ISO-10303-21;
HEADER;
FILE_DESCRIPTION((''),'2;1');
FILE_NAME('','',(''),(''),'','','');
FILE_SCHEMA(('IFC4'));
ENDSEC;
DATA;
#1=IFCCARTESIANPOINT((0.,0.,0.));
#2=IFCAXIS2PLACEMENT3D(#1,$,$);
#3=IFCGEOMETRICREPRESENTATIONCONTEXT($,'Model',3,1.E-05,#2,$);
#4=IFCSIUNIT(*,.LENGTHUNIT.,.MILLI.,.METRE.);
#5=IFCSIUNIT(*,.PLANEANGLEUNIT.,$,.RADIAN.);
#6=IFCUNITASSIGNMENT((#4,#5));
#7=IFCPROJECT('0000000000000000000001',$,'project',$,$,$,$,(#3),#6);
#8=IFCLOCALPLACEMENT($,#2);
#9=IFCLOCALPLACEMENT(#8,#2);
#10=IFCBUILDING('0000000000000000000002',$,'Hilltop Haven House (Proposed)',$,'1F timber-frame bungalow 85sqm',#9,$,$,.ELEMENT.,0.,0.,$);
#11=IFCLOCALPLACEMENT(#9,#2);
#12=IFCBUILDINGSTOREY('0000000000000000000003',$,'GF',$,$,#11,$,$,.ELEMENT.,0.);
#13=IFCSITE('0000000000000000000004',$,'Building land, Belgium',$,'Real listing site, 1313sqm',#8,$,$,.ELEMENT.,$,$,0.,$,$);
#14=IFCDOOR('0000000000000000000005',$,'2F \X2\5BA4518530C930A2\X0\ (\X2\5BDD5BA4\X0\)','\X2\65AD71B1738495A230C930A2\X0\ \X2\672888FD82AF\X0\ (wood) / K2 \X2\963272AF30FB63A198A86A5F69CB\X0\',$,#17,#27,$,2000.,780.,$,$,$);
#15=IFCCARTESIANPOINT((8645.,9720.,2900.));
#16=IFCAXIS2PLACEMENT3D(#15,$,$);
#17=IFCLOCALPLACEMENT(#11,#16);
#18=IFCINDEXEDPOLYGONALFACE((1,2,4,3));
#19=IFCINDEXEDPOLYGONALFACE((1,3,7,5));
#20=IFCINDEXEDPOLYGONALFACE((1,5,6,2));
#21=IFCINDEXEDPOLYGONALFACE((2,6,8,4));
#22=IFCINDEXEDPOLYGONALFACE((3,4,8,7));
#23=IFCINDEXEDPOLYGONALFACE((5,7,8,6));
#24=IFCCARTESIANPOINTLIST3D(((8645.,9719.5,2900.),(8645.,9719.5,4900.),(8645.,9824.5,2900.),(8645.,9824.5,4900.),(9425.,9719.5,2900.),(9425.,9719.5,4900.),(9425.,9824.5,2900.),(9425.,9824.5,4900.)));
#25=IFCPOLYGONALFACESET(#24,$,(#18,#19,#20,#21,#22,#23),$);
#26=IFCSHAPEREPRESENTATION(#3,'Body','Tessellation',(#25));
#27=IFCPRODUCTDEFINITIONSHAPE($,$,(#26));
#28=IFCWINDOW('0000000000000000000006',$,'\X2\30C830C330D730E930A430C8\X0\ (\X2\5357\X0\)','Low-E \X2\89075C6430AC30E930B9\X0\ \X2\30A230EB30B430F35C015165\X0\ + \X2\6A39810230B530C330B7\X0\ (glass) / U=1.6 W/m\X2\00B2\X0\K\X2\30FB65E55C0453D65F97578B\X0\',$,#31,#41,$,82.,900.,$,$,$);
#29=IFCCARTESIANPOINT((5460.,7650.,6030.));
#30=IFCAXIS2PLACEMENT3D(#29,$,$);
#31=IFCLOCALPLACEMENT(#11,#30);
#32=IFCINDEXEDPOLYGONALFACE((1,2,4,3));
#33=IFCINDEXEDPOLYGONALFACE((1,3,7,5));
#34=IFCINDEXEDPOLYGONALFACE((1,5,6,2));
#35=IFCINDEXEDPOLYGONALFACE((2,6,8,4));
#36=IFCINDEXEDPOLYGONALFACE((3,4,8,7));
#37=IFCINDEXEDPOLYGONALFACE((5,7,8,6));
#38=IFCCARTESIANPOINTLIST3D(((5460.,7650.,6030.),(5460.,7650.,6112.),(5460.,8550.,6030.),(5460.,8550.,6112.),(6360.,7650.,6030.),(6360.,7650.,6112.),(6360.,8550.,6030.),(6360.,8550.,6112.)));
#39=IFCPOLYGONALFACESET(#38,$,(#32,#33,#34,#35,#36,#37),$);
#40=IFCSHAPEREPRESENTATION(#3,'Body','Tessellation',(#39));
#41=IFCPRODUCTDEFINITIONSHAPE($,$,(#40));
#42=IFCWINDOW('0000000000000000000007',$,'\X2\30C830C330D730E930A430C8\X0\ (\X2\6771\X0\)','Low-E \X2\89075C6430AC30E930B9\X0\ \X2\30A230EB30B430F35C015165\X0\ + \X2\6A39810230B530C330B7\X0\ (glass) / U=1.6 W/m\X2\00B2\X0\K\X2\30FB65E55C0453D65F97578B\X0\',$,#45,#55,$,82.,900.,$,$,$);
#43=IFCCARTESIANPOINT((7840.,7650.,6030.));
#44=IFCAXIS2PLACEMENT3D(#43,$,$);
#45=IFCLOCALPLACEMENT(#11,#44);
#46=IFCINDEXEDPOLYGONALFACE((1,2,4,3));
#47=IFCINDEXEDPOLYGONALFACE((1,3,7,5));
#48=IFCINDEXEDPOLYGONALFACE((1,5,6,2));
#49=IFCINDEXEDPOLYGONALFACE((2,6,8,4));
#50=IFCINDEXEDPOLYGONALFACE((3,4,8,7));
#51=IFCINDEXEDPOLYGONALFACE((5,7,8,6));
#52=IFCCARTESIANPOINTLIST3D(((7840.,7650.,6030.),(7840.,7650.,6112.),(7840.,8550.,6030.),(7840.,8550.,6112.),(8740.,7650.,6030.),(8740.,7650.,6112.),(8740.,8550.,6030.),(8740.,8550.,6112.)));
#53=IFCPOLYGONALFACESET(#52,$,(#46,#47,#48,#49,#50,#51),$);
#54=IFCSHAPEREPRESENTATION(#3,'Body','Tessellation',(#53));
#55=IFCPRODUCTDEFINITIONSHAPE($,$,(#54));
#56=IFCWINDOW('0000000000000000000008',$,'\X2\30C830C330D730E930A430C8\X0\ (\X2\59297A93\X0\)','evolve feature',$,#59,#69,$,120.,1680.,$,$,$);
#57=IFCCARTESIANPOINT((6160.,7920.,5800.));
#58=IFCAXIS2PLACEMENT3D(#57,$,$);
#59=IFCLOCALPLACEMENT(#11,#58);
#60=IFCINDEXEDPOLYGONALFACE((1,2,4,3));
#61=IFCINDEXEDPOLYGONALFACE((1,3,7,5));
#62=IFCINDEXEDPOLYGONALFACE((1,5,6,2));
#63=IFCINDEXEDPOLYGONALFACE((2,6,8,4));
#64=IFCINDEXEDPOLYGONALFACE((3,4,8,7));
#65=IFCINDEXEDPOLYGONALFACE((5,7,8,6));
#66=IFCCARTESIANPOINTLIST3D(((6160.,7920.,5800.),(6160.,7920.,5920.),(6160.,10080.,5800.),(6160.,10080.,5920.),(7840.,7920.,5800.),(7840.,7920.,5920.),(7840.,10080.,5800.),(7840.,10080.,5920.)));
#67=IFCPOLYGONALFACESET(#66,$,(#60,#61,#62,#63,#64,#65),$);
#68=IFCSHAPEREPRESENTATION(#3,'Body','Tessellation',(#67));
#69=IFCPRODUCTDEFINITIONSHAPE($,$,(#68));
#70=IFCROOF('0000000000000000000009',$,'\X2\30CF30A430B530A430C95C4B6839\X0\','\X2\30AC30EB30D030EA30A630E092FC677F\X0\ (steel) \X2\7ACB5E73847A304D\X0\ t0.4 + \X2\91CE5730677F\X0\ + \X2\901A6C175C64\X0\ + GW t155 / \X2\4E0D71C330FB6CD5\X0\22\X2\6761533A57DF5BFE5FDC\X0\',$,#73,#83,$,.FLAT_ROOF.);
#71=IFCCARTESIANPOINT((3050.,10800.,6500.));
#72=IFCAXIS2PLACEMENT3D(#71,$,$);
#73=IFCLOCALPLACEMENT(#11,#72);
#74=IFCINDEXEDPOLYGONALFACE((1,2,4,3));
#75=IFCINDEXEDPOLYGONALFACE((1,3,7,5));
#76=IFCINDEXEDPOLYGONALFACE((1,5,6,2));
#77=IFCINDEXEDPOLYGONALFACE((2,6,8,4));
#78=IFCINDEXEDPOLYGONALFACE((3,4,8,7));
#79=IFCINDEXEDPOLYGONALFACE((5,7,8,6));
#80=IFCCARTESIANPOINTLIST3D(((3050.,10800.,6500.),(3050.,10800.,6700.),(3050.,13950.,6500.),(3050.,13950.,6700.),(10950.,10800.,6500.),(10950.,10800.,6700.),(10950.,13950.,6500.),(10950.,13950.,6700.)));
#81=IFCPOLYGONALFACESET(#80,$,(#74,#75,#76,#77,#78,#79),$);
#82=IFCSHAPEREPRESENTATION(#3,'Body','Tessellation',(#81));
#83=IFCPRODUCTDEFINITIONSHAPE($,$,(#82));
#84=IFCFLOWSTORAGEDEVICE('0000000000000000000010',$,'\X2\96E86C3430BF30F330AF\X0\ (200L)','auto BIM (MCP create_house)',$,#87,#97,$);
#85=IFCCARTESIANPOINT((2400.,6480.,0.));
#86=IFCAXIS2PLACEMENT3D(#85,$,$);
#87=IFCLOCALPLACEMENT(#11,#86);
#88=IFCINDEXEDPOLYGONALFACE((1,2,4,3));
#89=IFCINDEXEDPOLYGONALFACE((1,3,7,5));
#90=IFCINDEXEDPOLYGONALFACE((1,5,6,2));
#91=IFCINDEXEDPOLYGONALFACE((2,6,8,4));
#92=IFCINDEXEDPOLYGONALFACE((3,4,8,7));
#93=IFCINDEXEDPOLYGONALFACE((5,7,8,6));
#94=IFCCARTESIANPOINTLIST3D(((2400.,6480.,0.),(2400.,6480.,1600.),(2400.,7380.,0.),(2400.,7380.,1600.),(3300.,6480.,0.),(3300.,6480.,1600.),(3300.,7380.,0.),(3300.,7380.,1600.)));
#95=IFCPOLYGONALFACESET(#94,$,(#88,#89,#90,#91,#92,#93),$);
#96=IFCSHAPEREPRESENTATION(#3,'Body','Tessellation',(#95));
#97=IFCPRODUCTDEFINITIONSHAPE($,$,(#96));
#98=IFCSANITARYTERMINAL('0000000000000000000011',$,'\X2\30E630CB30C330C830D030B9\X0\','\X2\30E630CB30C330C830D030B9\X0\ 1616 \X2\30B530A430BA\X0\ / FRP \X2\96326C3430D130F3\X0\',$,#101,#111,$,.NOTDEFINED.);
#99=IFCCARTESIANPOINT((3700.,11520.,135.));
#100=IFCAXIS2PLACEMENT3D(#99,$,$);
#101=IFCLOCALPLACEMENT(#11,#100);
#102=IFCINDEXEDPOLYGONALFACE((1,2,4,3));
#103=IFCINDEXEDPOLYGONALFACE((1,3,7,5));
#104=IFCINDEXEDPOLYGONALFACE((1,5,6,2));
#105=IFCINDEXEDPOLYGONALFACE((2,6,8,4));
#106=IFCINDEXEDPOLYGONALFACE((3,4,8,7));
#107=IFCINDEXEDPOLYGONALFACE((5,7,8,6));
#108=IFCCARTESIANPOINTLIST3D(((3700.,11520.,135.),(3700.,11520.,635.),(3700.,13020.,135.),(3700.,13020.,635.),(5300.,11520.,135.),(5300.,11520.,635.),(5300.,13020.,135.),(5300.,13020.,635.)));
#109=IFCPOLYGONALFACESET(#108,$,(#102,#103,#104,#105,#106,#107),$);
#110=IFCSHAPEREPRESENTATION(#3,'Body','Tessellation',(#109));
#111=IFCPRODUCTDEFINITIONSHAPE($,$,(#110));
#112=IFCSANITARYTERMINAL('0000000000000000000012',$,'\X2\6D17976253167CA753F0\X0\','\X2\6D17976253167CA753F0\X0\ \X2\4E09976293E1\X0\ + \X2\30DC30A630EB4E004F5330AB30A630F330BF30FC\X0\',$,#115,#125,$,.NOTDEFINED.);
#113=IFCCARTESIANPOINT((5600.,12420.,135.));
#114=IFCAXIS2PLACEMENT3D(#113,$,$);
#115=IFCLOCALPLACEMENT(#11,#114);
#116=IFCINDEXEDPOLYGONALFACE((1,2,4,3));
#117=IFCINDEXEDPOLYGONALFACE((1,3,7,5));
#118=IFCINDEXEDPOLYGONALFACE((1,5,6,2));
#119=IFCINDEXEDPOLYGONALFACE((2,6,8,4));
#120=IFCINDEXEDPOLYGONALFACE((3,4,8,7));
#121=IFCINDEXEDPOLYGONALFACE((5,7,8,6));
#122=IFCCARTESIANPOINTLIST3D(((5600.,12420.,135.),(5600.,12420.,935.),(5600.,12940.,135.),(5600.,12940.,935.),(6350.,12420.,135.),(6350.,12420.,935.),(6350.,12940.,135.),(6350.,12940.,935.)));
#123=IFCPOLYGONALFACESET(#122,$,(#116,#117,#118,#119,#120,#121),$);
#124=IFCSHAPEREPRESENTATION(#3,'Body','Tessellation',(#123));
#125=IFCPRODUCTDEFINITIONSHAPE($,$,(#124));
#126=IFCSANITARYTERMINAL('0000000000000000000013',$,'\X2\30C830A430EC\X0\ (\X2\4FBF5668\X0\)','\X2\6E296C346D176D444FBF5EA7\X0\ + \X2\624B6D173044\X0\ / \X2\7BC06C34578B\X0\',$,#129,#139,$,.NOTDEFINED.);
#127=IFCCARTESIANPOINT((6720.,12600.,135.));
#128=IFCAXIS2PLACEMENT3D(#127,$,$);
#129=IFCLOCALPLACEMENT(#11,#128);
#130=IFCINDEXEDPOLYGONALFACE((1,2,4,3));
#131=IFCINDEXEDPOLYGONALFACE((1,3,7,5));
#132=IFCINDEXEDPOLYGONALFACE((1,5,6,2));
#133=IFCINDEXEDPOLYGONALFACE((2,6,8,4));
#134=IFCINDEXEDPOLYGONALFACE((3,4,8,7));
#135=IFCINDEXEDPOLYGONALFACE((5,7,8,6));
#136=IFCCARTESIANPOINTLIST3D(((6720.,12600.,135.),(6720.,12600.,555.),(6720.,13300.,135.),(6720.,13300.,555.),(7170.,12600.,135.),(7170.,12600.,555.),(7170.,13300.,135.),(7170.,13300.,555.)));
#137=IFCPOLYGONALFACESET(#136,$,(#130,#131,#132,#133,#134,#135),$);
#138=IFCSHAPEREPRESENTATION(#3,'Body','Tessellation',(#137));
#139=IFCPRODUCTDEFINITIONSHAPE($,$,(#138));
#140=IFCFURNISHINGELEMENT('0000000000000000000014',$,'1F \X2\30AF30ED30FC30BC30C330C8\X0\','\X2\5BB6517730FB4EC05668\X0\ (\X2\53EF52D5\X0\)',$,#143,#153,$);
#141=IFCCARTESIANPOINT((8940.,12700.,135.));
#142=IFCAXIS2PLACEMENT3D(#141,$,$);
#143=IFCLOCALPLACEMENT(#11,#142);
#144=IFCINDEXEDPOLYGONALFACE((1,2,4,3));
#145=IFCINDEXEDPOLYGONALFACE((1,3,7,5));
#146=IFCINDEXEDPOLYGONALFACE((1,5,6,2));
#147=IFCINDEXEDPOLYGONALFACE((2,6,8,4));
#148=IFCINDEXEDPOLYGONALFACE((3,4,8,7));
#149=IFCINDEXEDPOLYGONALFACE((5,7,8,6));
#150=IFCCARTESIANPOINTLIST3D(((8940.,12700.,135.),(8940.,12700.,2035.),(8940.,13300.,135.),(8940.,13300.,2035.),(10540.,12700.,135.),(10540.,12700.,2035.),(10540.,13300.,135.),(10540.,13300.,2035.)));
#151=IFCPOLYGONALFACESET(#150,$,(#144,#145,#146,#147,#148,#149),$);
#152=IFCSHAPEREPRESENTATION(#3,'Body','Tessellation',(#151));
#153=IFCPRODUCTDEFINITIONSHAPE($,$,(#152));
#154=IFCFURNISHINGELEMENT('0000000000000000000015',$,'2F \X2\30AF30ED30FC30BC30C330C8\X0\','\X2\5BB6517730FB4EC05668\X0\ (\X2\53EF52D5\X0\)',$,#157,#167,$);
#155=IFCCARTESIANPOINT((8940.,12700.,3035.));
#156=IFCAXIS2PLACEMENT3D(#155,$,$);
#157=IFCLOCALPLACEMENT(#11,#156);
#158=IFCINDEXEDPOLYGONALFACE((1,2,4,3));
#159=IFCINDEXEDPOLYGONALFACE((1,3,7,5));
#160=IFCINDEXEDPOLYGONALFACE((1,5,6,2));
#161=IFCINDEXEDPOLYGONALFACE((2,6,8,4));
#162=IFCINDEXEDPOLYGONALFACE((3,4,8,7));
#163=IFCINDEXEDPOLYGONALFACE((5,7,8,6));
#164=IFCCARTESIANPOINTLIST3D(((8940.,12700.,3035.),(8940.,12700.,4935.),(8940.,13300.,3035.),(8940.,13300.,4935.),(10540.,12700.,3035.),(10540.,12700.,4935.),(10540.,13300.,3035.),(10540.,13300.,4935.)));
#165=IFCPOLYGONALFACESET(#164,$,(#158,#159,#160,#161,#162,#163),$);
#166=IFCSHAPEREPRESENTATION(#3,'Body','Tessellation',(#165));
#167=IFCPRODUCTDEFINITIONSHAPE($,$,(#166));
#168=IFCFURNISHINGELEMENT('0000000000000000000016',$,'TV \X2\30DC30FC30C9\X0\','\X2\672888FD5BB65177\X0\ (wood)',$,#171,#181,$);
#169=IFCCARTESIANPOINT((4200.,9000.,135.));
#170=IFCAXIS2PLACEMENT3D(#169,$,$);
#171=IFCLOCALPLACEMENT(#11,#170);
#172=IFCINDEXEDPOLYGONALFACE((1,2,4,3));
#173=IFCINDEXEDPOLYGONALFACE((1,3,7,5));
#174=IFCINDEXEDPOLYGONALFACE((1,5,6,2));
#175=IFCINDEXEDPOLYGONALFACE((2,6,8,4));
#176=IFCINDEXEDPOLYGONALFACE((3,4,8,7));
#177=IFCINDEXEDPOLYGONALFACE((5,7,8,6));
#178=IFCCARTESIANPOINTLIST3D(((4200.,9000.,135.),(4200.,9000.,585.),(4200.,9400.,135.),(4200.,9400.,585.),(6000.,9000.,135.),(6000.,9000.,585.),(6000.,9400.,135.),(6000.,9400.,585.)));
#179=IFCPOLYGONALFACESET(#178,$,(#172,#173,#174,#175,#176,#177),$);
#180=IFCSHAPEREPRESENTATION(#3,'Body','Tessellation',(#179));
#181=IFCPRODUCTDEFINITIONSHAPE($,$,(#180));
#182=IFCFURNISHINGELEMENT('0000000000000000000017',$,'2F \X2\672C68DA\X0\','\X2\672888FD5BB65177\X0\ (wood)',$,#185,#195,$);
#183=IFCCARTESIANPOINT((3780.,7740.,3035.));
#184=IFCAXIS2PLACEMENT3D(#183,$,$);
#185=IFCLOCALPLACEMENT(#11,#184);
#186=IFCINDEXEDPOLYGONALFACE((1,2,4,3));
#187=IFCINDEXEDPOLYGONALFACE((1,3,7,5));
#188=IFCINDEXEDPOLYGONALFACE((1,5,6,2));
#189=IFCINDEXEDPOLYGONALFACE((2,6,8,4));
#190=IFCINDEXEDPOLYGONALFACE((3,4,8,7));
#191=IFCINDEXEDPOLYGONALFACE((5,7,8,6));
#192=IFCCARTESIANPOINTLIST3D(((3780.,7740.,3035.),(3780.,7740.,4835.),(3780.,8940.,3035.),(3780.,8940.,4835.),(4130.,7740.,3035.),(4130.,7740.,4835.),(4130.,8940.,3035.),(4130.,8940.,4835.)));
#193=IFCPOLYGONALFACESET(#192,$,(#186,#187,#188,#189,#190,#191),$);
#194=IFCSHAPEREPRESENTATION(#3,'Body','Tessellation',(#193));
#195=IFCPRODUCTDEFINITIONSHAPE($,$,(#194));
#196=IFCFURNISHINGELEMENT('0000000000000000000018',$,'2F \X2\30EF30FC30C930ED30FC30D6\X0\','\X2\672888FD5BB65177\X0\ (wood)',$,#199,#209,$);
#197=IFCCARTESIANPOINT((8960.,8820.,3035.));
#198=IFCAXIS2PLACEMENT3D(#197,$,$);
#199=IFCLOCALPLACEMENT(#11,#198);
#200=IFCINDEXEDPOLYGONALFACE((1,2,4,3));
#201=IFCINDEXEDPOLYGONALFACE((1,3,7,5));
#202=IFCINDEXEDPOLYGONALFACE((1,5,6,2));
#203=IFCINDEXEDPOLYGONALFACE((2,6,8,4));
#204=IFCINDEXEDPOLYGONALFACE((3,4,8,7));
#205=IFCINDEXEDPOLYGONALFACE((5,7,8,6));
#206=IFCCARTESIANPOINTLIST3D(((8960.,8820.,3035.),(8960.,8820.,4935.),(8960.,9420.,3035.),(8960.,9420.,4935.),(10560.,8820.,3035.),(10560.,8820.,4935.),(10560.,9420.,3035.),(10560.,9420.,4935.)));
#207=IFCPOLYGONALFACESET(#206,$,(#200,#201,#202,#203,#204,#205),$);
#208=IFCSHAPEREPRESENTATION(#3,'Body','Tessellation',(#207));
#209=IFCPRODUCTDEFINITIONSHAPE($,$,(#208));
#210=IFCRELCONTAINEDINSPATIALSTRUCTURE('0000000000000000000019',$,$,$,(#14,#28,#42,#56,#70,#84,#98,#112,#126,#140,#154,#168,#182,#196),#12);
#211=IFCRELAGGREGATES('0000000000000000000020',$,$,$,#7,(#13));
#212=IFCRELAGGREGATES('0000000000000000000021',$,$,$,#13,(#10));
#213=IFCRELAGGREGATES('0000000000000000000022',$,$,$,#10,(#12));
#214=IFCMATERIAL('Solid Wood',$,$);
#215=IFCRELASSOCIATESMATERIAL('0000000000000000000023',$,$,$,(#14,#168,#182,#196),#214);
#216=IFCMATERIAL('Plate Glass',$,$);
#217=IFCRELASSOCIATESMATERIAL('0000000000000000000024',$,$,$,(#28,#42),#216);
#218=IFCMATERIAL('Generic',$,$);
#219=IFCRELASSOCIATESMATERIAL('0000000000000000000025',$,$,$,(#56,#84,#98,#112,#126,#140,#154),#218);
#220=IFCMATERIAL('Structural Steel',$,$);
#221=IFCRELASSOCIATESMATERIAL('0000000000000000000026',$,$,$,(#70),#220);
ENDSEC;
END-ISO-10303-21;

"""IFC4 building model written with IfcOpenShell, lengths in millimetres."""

from ifc_helpers import new_model, si_unit, frame, frame_2d, origin, place, context, project, spatial, rectangle, extrude, material, element, save


model = new_model("IFC4")

# Units and contexts
model_context = context("Model", 3, precision=1e-05, world=origin())
ifc_project = project(units=[si_unit("LENGTHUNIT", "METRE", prefix="MILLI"), si_unit("PLANEANGLEUNIT", "RADIAN")], contexts=[model_context])

# Site, building, storey
site_placement = place(None, origin())
site = spatial("IfcSite", under=ifc_project, at=site_placement, Name="Building land, Belgium", ObjectType="Real listing site, 1313sqm", CompositionType="ELEMENT", RefElevation=0.0)
building_placement = place(site_placement, origin())
building = spatial("IfcBuilding", under=site, at=building_placement, Name="Hilltop Haven House (Proposed)", ObjectType="1F timber-frame bungalow 85sqm", CompositionType="ELEMENT", ElevationOfRefHeight=0.0, ElevationOfTerrain=0.0)
storey_placement = place(building_placement, origin())
storey = spatial("IfcBuildingStorey", under=building, at=storey_placement, Name="GF", CompositionType="ELEMENT", Elevation=0.0)

# Shared definitions
ifc_material_1 = material(Name="Solid Wood")
ifc_material_2 = material(Name="Plate Glass")

# Door
door_1_placement = place(storey_placement, frame((8645.0, 9720.0, 2900.0)))
element("IfcDoor", 1, at=door_1_placement, inside=storey, material=ifc_material_1, Name="2F 室内ドア (寝室)", Description="断熱玄関ドア 木製芯 (wood) / K2 防犯・採風機構", OverallHeight=2000.0, OverallWidth=780.0, context=model_context, shape_type="SweptSolid", body=[
    extrude(rectangle(XDim=780.0, YDim=105.0, at=frame_2d((390.0, 52.0))), frame((8645.0, 9720.0, 2900.0)), (0.0, 0.0, 1.0), 2000.0),
])

# Windows
window_1_placement = place(storey_placement, frame((5460.0, 7650.0, 6030.0)))
element("IfcWindow", 2, at=window_1_placement, inside=storey, material=ifc_material_2, Name="トップライト (南)", Description="Low-E 複層ガラス アルゴン封入 + 樹脂サッシ (glass) / U=1.6 W/m²K・日射取得型", OverallHeight=82.0, OverallWidth=900.0, context=model_context, shape_type="SweptSolid", body=[
    extrude(rectangle(XDim=900.0, YDim=900.0, at=frame_2d((450.0, 450.0))), frame((5460.0, 7650.0, 6030.0)), (0.0, 0.0, 1.0), 82.0),
])
window_2_placement = place(storey_placement, frame((7840.0, 7650.0, 6030.0)))
element("IfcWindow", 3, at=window_2_placement, inside=storey, material=ifc_material_2, Name="トップライト (東)", Description="Low-E 複層ガラス アルゴン封入 + 樹脂サッシ (glass) / U=1.6 W/m²K・日射取得型", OverallHeight=82.0, OverallWidth=900.0, context=model_context, shape_type="SweptSolid", body=[
    extrude(rectangle(XDim=900.0, YDim=900.0, at=frame_2d((450.0, 450.0))), frame((7840.0, 7650.0, 6030.0)), (0.0, 0.0, 1.0), 82.0),
])
ifc_material_3 = material(Name="Generic")
window_3_placement = place(storey_placement, frame((6160.0, 7920.0, 5800.0)))
element("IfcWindow", 4, at=window_3_placement, inside=storey, material=ifc_material_3, Name="トップライト (天窓)", Description="evolve feature", OverallHeight=120.0, OverallWidth=1680.0, context=model_context, shape_type="SweptSolid", body=[
    extrude(rectangle(XDim=1680.0, YDim=2160.0, at=frame_2d((840.0, 1080.0))), frame((6160.0, 7920.0, 5800.0)), (0.0, 0.0, 1.0), 120.0),
])

# Roof
ifc_material_4 = material(Name="Structural Steel")
roof_placement = place(storey_placement, frame((3050.0, 10800.0, 6500.0)))
element("IfcRoof", 5, at=roof_placement, inside=storey, material=ifc_material_4, Name="ハイサイド屋根", Description="ガルバリウム鋼板 (steel) 立平葺き t0.4 + 野地板 + 通気層 + GW t155 / 不燃・法22条区域対応", PredefinedType="FLAT_ROOF", context=model_context, shape_type="SweptSolid", body=[
    extrude(rectangle(XDim=7900.0, YDim=3150.0, at=frame_2d((3950.0, 1575.0))), frame((3050.0, 10800.0, 6500.0)), (0.0, 0.0, 1.0), 200.0),
])

# Flow storage device
flow_storage_device_placement = place(storey_placement, frame((2400.0, 6480.0, 0.0)))
element("IfcFlowStorageDevice", 6, at=flow_storage_device_placement, inside=storey, material=ifc_material_3, Name="雨水タンク (200L)", Description="auto BIM (MCP create_house)", context=model_context, shape_type="SweptSolid", body=[
    extrude(rectangle(XDim=900.0, YDim=900.0, at=frame_2d((450.0, 450.0))), frame((2400.0, 6480.0, 0.0)), (0.0, 0.0, 1.0), 1600.0),
])

# Sanitary terminals
sanitary_terminal_1_placement = place(storey_placement, frame((3700.0, 11520.0, 135.0)))
element("IfcSanitaryTerminal", 7, at=sanitary_terminal_1_placement, inside=storey, material=ifc_material_3, Name="ユニットバス", Description="ユニットバス 1616 サイズ / FRP 防水パン", PredefinedType="NOTDEFINED", context=model_context, shape_type="SweptSolid", body=[
    extrude(rectangle(XDim=1600.0, YDim=1500.0, at=frame_2d((800.0, 750.0))), frame((3700.0, 11520.0, 135.0)), (0.0, 0.0, 1.0), 500.0),
])
sanitary_terminal_2_placement = place(storey_placement, frame((5600.0, 12420.0, 135.0)))
element("IfcSanitaryTerminal", 8, at=sanitary_terminal_2_placement, inside=storey, material=ifc_material_3, Name="洗面化粧台", Description="洗面化粧台 三面鏡 + ボウル一体カウンター", PredefinedType="NOTDEFINED", context=model_context, shape_type="SweptSolid", body=[
    extrude(rectangle(XDim=750.0, YDim=520.0, at=frame_2d((375.0, 260.0))), frame((5600.0, 12420.0, 135.0)), (0.0, 0.0, 1.0), 800.0),
])
sanitary_terminal_3_placement = place(storey_placement, frame((6720.0, 12600.0, 135.0)))
element("IfcSanitaryTerminal", 9, at=sanitary_terminal_3_placement, inside=storey, material=ifc_material_3, Name="トイレ (便器)", Description="温水洗浄便座 + 手洗い / 節水型", PredefinedType="NOTDEFINED", context=model_context, shape_type="SweptSolid", body=[
    extrude(rectangle(XDim=450.0, YDim=700.0, at=frame_2d((225.0, 350.0))), frame((6720.0, 12600.0, 135.0)), (0.0, 0.0, 1.0), 420.0),
])

# Furnishing elements
furnishing_1_placement = place(storey_placement, frame((8940.0, 12700.0, 135.0)))
element("IfcFurnishingElement", 10, at=furnishing_1_placement, inside=storey, material=ifc_material_3, Name="1F クローゼット", Description="家具・什器 (可動)", context=model_context, shape_type="SweptSolid", body=[
    extrude(rectangle(XDim=1600.0, YDim=600.0, at=frame_2d((800.0, 300.0))), frame((8940.0, 12700.0, 135.0)), (0.0, 0.0, 1.0), 1900.0),
])
furnishing_2_placement = place(storey_placement, frame((8940.0, 12700.0, 3035.0)))
element("IfcFurnishingElement", 11, at=furnishing_2_placement, inside=storey, material=ifc_material_3, Name="2F クローゼット", Description="家具・什器 (可動)", context=model_context, shape_type="SweptSolid", body=[
    extrude(rectangle(XDim=1600.0, YDim=600.0, at=frame_2d((800.0, 300.0))), frame((8940.0, 12700.0, 3035.0)), (0.0, 0.0, 1.0), 1900.0),
])
furnishing_3_placement = place(storey_placement, frame((4200.0, 9000.0, 135.0)))
element("IfcFurnishingElement", 12, at=furnishing_3_placement, inside=storey, material=ifc_material_1, Name="TV ボード", Description="木製家具 (wood)", context=model_context, shape_type="SweptSolid", body=[
    extrude(rectangle(XDim=1800.0, YDim=400.0, at=frame_2d((900.0, 200.0))), frame((4200.0, 9000.0, 135.0)), (0.0, 0.0, 1.0), 450.0),
])
furnishing_4_placement = place(storey_placement, frame((3780.0, 7740.0, 3035.0)))
element("IfcFurnishingElement", 13, at=furnishing_4_placement, inside=storey, material=ifc_material_1, Name="2F 本棚", Description="木製家具 (wood)", context=model_context, shape_type="SweptSolid", body=[
    extrude(rectangle(XDim=350.0, YDim=1200.0, at=frame_2d((175.0, 600.0))), frame((3780.0, 7740.0, 3035.0)), (0.0, 0.0, 1.0), 1800.0),
])
furnishing_5_placement = place(storey_placement, frame((8960.0, 8820.0, 3035.0)))
element("IfcFurnishingElement", 14, at=furnishing_5_placement, inside=storey, material=ifc_material_1, Name="2F ワードローブ", Description="木製家具 (wood)", context=model_context, shape_type="SweptSolid", body=[
    extrude(rectangle(XDim=1600.0, YDim=600.0, at=frame_2d((800.0, 300.0))), frame((8960.0, 8820.0, 3035.0)), (0.0, 0.0, 1.0), 1900.0),
])

save(model, "model.ifc")
